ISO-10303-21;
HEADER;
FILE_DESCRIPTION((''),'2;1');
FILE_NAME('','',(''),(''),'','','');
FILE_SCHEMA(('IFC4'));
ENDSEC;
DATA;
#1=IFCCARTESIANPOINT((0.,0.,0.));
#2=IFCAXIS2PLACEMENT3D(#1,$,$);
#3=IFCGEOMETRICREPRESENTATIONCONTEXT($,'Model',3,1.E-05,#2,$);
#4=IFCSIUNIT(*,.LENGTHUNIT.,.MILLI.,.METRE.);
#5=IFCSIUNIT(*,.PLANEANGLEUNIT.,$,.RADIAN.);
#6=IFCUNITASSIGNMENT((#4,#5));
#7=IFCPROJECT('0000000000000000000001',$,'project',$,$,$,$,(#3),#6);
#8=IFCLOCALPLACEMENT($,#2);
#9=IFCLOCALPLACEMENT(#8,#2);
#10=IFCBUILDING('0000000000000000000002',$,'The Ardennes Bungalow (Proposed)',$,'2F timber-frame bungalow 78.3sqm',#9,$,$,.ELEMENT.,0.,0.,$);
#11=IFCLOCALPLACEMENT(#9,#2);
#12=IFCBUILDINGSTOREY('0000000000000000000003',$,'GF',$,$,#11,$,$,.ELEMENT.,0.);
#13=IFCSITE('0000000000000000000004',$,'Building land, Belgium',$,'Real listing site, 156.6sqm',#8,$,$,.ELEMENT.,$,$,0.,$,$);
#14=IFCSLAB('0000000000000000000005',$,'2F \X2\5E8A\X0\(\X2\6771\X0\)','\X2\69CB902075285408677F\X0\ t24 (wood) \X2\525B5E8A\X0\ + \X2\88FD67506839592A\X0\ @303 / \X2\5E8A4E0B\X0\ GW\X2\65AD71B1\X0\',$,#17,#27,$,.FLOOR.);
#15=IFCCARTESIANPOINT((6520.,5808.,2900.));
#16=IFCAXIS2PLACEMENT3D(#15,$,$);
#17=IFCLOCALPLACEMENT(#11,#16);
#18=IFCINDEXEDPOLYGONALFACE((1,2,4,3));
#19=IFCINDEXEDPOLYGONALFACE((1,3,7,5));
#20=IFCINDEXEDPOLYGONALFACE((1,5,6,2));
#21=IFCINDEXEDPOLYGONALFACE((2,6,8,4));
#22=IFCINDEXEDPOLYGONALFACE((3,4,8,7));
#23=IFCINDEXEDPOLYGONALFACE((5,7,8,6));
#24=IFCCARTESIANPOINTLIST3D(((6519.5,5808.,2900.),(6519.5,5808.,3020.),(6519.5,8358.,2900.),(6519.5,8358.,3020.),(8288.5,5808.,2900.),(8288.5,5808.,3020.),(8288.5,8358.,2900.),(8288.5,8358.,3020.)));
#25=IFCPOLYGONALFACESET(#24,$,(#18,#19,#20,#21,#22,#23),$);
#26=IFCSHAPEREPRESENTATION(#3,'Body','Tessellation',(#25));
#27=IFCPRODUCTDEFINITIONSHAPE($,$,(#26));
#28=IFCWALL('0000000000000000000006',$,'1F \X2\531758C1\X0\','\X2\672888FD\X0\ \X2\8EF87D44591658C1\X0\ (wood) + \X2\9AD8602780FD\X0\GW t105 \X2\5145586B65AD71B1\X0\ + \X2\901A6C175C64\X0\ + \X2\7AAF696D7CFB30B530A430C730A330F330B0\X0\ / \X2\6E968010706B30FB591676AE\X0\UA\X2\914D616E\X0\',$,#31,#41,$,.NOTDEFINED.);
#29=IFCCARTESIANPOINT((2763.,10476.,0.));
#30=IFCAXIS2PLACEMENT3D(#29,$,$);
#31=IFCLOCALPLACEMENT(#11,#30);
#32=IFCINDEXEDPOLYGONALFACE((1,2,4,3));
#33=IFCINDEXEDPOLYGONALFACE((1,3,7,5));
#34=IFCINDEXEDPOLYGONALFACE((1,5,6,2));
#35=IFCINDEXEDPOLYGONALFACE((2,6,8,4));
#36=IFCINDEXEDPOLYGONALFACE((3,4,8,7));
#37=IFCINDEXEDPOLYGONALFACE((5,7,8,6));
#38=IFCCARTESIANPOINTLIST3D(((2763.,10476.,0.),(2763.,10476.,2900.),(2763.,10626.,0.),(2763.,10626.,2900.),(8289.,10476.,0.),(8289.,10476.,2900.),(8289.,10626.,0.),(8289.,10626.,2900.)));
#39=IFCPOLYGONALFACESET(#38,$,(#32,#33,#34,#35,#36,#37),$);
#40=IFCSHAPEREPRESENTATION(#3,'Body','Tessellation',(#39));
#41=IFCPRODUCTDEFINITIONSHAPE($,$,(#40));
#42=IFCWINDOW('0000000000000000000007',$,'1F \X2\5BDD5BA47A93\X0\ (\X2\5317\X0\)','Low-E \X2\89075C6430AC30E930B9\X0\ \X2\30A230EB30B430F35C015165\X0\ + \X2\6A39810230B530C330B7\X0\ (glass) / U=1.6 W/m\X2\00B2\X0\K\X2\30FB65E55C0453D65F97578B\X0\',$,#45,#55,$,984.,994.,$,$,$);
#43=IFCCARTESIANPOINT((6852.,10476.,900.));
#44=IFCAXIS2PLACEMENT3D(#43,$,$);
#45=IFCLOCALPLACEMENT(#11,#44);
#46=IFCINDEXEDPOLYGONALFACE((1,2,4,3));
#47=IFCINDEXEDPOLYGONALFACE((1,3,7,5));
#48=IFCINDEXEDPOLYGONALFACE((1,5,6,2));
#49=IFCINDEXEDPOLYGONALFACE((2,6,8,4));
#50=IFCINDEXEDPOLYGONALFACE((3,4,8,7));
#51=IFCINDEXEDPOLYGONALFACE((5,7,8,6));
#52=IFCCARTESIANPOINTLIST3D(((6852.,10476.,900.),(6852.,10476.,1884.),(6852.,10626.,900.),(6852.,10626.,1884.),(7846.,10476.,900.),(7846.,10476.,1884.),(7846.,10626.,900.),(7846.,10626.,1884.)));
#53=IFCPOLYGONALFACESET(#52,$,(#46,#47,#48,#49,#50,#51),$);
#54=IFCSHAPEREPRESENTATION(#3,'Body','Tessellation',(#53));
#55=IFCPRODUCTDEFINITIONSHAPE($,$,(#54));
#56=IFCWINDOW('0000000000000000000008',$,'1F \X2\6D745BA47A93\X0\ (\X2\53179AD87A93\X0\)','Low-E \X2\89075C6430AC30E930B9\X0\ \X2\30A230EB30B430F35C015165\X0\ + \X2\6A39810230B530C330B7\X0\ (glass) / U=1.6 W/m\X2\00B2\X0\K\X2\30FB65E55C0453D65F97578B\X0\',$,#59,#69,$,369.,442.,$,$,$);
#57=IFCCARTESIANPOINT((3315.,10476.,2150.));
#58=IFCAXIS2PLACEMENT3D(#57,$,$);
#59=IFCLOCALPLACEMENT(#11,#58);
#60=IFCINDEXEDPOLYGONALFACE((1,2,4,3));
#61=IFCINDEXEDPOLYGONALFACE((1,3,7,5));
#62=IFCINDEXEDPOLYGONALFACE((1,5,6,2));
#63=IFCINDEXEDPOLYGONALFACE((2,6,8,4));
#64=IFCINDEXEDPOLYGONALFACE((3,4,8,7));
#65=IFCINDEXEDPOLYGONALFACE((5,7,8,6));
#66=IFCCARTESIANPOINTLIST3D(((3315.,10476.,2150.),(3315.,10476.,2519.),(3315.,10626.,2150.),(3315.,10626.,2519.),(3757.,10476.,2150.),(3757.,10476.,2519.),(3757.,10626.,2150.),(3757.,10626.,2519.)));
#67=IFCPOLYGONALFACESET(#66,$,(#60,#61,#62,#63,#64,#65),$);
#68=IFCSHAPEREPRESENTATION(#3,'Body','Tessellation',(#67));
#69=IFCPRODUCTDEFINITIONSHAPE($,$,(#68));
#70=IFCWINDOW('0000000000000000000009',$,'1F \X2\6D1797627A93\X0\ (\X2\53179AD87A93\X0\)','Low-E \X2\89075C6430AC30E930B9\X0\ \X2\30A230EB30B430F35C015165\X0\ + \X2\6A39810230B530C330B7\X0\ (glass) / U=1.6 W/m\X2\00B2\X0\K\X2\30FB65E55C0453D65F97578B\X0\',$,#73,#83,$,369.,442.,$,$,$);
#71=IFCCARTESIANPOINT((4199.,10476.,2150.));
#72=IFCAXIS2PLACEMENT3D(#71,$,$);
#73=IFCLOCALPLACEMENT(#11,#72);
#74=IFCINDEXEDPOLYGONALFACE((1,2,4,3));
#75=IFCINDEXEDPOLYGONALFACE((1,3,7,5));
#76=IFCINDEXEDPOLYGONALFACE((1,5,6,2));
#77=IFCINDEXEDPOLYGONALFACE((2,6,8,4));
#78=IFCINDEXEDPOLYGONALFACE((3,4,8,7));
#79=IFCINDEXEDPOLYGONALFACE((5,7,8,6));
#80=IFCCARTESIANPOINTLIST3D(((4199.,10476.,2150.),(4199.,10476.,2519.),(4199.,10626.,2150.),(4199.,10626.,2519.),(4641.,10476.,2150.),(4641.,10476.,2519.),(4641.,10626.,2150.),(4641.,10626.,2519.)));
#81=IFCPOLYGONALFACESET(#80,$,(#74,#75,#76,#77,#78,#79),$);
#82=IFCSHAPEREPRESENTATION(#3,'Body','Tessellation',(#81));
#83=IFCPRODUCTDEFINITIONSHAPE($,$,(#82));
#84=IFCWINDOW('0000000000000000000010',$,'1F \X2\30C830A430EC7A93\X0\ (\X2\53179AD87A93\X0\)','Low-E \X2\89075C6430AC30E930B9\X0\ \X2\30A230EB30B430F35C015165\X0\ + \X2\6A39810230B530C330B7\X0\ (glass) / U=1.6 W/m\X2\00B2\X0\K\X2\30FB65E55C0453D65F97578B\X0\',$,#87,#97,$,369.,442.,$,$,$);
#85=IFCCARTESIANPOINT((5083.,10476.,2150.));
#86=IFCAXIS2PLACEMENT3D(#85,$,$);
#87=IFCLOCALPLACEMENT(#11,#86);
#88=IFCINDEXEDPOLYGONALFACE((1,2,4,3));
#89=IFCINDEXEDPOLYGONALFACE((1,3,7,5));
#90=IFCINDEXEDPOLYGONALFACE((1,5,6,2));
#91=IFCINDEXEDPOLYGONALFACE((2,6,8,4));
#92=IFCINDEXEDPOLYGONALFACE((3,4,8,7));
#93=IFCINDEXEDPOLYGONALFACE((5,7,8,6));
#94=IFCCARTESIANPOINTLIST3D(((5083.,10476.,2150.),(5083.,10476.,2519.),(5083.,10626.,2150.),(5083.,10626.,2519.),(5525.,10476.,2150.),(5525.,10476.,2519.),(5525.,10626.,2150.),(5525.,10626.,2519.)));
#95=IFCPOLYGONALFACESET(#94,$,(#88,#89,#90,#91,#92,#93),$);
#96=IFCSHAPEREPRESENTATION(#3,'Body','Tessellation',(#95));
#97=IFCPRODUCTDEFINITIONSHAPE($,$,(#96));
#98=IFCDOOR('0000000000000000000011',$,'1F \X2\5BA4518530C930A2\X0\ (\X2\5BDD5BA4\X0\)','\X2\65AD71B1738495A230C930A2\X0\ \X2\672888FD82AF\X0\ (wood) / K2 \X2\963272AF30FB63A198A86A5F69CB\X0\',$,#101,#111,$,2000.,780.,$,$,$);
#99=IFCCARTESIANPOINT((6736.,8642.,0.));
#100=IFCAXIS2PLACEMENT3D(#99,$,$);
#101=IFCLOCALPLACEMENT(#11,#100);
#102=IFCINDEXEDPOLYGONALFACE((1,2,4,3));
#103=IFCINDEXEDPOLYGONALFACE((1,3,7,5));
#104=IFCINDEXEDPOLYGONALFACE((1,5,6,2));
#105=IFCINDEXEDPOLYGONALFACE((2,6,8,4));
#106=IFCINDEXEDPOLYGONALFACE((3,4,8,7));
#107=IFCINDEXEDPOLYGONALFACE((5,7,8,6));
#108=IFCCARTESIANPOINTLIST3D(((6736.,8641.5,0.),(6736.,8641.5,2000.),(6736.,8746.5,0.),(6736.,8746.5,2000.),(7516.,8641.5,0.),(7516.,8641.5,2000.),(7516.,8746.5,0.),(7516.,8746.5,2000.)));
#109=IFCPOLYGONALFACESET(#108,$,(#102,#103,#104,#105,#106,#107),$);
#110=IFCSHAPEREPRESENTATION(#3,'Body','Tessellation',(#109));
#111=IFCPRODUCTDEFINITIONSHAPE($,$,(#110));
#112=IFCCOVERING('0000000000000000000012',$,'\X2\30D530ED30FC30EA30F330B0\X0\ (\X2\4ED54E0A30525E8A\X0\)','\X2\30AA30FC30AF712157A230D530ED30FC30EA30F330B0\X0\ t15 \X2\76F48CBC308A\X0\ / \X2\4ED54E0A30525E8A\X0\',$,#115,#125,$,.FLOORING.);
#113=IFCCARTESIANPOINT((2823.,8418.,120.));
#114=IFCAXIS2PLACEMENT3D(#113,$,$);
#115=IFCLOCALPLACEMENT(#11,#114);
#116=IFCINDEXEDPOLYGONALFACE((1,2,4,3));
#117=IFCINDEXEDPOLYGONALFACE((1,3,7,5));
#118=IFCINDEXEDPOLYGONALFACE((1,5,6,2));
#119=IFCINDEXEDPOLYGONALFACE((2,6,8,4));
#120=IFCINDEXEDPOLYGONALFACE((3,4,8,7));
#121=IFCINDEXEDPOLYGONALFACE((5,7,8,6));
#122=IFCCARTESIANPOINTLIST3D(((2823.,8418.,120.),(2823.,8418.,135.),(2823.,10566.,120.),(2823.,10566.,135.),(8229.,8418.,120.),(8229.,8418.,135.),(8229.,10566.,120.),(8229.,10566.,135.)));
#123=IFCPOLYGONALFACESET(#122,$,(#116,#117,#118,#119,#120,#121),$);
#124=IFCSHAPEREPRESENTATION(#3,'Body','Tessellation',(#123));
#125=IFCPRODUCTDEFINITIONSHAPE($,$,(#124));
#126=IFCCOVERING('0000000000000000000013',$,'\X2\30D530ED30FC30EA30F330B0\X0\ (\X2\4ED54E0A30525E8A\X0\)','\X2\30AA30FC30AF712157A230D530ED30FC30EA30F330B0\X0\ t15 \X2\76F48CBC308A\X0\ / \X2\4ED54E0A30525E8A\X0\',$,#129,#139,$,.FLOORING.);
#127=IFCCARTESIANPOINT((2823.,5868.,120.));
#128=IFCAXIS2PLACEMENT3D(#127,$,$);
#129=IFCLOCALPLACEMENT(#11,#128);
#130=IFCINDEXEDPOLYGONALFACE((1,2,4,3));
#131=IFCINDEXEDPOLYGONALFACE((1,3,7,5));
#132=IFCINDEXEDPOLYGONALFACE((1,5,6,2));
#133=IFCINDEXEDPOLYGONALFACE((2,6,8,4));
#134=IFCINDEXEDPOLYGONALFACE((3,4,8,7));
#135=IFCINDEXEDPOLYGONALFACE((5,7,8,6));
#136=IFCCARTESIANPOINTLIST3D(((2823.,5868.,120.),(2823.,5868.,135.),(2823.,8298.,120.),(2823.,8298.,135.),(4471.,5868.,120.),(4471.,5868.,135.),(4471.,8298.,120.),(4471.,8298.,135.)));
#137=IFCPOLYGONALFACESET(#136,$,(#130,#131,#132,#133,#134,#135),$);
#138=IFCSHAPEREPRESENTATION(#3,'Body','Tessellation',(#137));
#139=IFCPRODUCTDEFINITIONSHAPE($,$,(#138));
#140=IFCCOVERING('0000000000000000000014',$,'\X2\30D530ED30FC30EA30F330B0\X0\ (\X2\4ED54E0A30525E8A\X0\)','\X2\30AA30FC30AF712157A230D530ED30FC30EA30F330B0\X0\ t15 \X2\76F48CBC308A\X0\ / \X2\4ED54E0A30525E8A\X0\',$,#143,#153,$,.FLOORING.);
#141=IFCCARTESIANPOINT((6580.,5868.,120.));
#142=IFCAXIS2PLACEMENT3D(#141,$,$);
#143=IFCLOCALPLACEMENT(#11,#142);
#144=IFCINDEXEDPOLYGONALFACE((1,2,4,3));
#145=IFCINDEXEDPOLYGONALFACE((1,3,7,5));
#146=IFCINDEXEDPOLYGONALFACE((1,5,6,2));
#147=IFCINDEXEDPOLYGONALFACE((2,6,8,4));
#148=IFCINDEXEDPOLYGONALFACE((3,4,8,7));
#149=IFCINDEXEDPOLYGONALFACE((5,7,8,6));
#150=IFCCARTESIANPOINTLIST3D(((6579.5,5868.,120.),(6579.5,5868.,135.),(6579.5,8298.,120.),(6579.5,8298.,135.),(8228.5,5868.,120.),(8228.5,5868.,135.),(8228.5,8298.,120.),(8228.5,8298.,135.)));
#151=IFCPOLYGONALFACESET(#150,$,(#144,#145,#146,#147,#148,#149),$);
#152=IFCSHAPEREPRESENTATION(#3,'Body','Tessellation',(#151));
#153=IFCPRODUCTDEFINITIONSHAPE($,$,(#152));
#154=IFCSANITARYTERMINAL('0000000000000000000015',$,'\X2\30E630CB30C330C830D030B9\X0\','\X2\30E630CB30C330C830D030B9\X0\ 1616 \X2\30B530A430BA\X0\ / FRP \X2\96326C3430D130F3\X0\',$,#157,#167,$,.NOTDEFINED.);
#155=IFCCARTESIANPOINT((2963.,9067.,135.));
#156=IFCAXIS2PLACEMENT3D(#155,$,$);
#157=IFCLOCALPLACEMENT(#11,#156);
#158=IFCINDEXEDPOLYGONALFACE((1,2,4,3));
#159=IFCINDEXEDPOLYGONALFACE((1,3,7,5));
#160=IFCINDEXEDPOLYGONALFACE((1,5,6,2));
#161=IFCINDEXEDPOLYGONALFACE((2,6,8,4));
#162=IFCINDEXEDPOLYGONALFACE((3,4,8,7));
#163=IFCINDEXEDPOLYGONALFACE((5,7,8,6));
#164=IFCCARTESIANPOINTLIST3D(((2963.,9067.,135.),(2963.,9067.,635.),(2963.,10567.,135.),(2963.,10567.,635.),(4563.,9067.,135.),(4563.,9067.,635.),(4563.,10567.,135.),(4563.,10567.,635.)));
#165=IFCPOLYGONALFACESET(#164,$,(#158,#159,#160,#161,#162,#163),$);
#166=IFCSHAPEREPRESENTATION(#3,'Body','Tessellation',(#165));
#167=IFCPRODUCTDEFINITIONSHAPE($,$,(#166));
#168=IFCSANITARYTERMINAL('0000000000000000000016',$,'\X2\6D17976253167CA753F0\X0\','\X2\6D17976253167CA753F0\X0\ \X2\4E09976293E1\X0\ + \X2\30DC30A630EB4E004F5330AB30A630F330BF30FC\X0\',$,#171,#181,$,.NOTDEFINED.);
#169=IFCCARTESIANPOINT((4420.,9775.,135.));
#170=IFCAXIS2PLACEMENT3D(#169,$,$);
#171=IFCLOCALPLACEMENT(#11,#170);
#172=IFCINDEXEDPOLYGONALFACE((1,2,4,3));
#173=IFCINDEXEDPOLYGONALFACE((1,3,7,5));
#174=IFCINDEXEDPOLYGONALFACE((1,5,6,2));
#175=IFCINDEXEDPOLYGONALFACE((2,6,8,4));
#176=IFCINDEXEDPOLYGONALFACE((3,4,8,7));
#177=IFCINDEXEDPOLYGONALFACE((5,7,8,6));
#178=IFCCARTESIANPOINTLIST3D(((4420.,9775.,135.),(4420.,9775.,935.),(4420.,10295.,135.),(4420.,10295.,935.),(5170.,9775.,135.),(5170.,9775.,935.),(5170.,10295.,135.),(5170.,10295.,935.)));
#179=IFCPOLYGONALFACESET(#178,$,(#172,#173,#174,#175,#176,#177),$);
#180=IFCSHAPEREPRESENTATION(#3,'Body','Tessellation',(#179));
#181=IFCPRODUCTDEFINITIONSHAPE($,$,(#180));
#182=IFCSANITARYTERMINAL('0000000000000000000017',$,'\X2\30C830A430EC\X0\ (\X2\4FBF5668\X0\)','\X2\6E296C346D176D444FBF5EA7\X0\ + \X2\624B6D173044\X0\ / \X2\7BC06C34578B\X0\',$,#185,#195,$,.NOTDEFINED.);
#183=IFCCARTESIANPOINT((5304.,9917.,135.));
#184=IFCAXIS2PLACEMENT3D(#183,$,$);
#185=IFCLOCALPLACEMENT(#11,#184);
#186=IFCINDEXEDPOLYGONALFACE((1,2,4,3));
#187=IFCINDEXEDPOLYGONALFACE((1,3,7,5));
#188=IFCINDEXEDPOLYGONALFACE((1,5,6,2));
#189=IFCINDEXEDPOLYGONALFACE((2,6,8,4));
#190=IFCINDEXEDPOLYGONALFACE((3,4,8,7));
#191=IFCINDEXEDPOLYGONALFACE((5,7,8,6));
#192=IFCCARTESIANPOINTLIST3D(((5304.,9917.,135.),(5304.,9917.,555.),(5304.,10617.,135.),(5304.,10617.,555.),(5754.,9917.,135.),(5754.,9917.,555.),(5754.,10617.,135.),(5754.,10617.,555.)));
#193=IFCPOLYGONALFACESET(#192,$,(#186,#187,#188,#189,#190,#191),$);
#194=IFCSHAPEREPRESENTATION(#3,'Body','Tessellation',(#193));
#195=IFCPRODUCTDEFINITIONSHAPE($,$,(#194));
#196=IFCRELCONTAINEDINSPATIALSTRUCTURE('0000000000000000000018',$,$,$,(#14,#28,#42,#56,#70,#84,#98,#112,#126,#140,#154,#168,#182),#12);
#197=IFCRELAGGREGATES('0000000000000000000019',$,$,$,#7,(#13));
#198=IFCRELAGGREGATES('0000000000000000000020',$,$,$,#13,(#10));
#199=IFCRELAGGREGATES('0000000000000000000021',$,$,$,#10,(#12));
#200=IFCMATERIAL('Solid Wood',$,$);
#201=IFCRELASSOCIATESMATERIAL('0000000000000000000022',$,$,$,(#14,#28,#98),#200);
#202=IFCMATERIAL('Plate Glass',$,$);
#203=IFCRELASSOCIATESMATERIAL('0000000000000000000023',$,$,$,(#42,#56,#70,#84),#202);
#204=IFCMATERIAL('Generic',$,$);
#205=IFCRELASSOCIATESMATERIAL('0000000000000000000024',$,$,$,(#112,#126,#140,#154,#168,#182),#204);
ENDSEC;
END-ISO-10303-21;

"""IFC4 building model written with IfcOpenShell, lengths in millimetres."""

from ifc_helpers import new_model, si_unit, frame, frame_2d, origin, place, context, project, spatial, rectangle, extrude, material, element, fill, save


model = new_model("IFC4")

# Units and contexts
model_context = context("Model", 3, precision=1e-05, world=origin())
ifc_project = project(units=[si_unit("LENGTHUNIT", "METRE", prefix="MILLI"), si_unit("PLANEANGLEUNIT", "RADIAN")], contexts=[model_context])

# Site, building, storey
site_placement = place(None, origin())
site = spatial("IfcSite", under=ifc_project, at=site_placement, Name="Building land, Belgium", ObjectType="Real listing site, 156.6sqm", CompositionType="ELEMENT", RefElevation=0.0)
building_placement = place(site_placement, origin())
building = spatial("IfcBuilding", under=site, at=building_placement, Name="The Ardennes Bungalow (Proposed)", ObjectType="2F timber-frame bungalow 78.3sqm", CompositionType="ELEMENT", ElevationOfRefHeight=0.0, ElevationOfTerrain=0.0)
storey_placement = place(building_placement, origin())
storey = spatial("IfcBuildingStorey", under=building, at=storey_placement, Name="GF", CompositionType="ELEMENT", Elevation=0.0)

# Slab
ifc_material_1 = material(Name="Solid Wood")
slab_1_placement = place(storey_placement, frame((6520.0, 5808.0, 2900.0)))
element("IfcSlab", 1, at=slab_1_placement, inside=storey, material=ifc_material_1, Name="2F 床(東)", Description="構造用合板 t24 (wood) 剛床 + 製材根太 @303 / 床下 GW断熱", PredefinedType="FLOOR", context=model_context, shape_type="SweptSolid", body=[
    extrude(rectangle(XDim=1769.0, YDim=2550.0, at=frame_2d((884.0, 1275.0))), frame((6520.0, 5808.0, 2900.0)), (0.0, 0.0, 1.0), 120.0),
])

# Wall, openings, windows
wall_1_placement = place(storey_placement, frame((2763.0, 10476.0, 0.0)))
wall_1 = element("IfcWall", 2, at=wall_1_placement, inside=storey, material=ifc_material_1, Name="1F 北壁", Description="木製 軸組外壁 (wood) + 高性能GW t105 充填断熱 + 通気層 + 窯業系サイディング / 準耐火・外皮UA配慮", PredefinedType="NOTDEFINED", context=model_context, shape_type="SweptSolid", body=[
    extrude(rectangle(XDim=5526.0, YDim=150.0, at=frame_2d((2763.0, 75.0))), frame((2763.0, 10476.0, 0.0)), (0.0, 0.0, 1.0), 2900.0),
])
opening_1_placement = place(storey_placement, frame((6852.0, 10476.0, 900.0)))
opening_1 = element("IfcOpeningElement", 3, at=opening_1_placement, cuts=wall_1, PredefinedType="NOTDEFINED", context=model_context, shape_type="SweptSolid", body=[
    extrude(rectangle(XDim=994.0, YDim=150.0, at=frame_2d((497.0, 75.0))), frame((6852.0, 10476.0, 900.0)), (0.0, 0.0, 1.0), 984.0),
])
opening_2_placement = place(storey_placement, frame((3315.0, 10476.0, 2150.0)))
opening_2 = element("IfcOpeningElement", 4, at=opening_2_placement, cuts=wall_1, PredefinedType="NOTDEFINED", context=model_context, shape_type="SweptSolid", body=[
    extrude(rectangle(XDim=442.0, YDim=150.0, at=frame_2d((221.0, 75.0))), frame((3315.0, 10476.0, 2150.0)), (0.0, 0.0, 1.0), 369.0),
])
opening_3_placement = place(storey_placement, frame((4199.0, 10476.0, 2150.0)))
opening_3 = element("IfcOpeningElement", 5, at=opening_3_placement, cuts=wall_1, PredefinedType="NOTDEFINED", context=model_context, shape_type="SweptSolid", body=[
    extrude(rectangle(XDim=442.0, YDim=150.0, at=frame_2d((221.0, 75.0))), frame((4199.0, 10476.0, 2150.0)), (0.0, 0.0, 1.0), 369.0),
])
opening_4_placement = place(storey_placement, frame((5083.0, 10476.0, 2150.0)))
opening_4 = element("IfcOpeningElement", 6, at=opening_4_placement, cuts=wall_1, PredefinedType="NOTDEFINED", context=model_context, shape_type="SweptSolid", body=[
    extrude(rectangle(XDim=442.0, YDim=150.0, at=frame_2d((221.0, 75.0))), frame((5083.0, 10476.0, 2150.0)), (0.0, 0.0, 1.0), 369.0),
])
ifc_material_2 = material(Name="Plate Glass")
window_1_placement = place(storey_placement, frame((6852.0, 10476.0, 900.0)))
window_1 = element("IfcWindow", 7, at=window_1_placement, inside=storey, material=ifc_material_2, Name="1F 寝室窓 (北)", Description="Low-E 複層ガラス アルゴン封入 + 樹脂サッシ (glass) / U=1.6 W/m²K・日射取得型", OverallHeight=984.0, OverallWidth=994.0, context=model_context, shape_type="SweptSolid", body=[
    extrude(rectangle(XDim=994.0, YDim=150.0, at=frame_2d((497.0, 75.0))), frame((6852.0, 10476.0, 900.0)), (0.0, 0.0, 1.0), 984.0),
])
fill(opening_1, window_1)
window_2_placement = place(storey_placement, frame((3315.0, 10476.0, 2150.0)))
window_2 = element("IfcWindow", 8, at=window_2_placement, inside=storey, material=ifc_material_2, Name="1F 浴室窓 (北高窓)", Description="Low-E 複層ガラス アルゴン封入 + 樹脂サッシ (glass) / U=1.6 W/m²K・日射取得型", OverallHeight=369.0, OverallWidth=442.0, context=model_context, shape_type="SweptSolid", body=[
    extrude(rectangle(XDim=442.0, YDim=150.0, at=frame_2d((221.0, 75.0))), frame((3315.0, 10476.0, 2150.0)), (0.0, 0.0, 1.0), 369.0),
])
fill(opening_2, window_2)
window_3_placement = place(storey_placement, frame((4199.0, 10476.0, 2150.0)))
window_3 = element("IfcWindow", 9, at=window_3_placement, inside=storey, material=ifc_material_2, Name="1F 洗面窓 (北高窓)", Description="Low-E 複層ガラス アルゴン封入 + 樹脂サッシ (glass) / U=1.6 W/m²K・日射取得型", OverallHeight=369.0, OverallWidth=442.0, context=model_context, shape_type="SweptSolid", body=[
    extrude(rectangle(XDim=442.0, YDim=150.0, at=frame_2d((221.0, 75.0))), frame((4199.0, 10476.0, 2150.0)), (0.0, 0.0, 1.0), 369.0),
])
fill(opening_3, window_3)
window_4_placement = place(storey_placement, frame((5083.0, 10476.0, 2150.0)))
window_4 = element("IfcWindow", 10, at=window_4_placement, inside=storey, material=ifc_material_2, Name="1F トイレ窓 (北高窓)", Description="Low-E 複層ガラス アルゴン封入 + 樹脂サッシ (glass) / U=1.6 W/m²K・日射取得型", OverallHeight=369.0, OverallWidth=442.0, context=model_context, shape_type="SweptSolid", body=[
    extrude(rectangle(XDim=442.0, YDim=150.0, at=frame_2d((221.0, 75.0))), frame((5083.0, 10476.0, 2150.0)), (0.0, 0.0, 1.0), 369.0),
])
fill(opening_4, window_4)

# Door
door_1_placement = place(storey_placement, frame((6736.0, 8642.0, 0.0)))
element("IfcDoor", 11, at=door_1_placement, inside=storey, material=ifc_material_1, Name="1F 室内ドア (寝室)", Description="断熱玄関ドア 木製芯 (wood) / K2 防犯・採風機構", OverallHeight=2000.0, OverallWidth=780.0, context=model_context, shape_type="SweptSolid", body=[
    extrude(rectangle(XDim=780.0, YDim=105.0, at=frame_2d((390.0, 52.0))), frame((6736.0, 8642.0, 0.0)), (0.0, 0.0, 1.0), 2000.0),
])

# Coverings
ifc_material_3 = material(Name="Generic")
covering_1_placement = place(storey_placement, frame((2823.0, 8418.0, 120.0)))
element("IfcCovering", 12, at=covering_1_placement, inside=storey, material=ifc_material_3, Name="フローリング (仕上げ床)", Description="オーク無垢フローリング t15 直貼り / 仕上げ床", PredefinedType="FLOORING", context=model_context, shape_type="SweptSolid", body=[
    extrude(rectangle(XDim=5406.0, YDim=2148.0, at=frame_2d((2703.0, 1074.0))), frame((2823.0, 8418.0, 120.0)), (0.0, 0.0, 1.0), 15.0),
])
covering_2_placement = place(storey_placement, frame((2823.0, 5868.0, 120.0)))
element("IfcCovering", 13, at=covering_2_placement, inside=storey, material=ifc_material_3, Name="フローリング (仕上げ床)", Description="オーク無垢フローリング t15 直貼り / 仕上げ床", PredefinedType="FLOORING", context=model_context, shape_type="SweptSolid", body=[
    extrude(rectangle(XDim=1648.0, YDim=2430.0, at=frame_2d((824.0, 1215.0))), frame((2823.0, 5868.0, 120.0)), (0.0, 0.0, 1.0), 15.0),
])
covering_3_placement = place(storey_placement, frame((6580.0, 5868.0, 120.0)))
element("IfcCovering", 14, at=covering_3_placement, inside=storey, material=ifc_material_3, Name="フローリング (仕上げ床)", Description="オーク無垢フローリング t15 直貼り / 仕上げ床", PredefinedType="FLOORING", context=model_context, shape_type="SweptSolid", body=[
    extrude(rectangle(XDim=1649.0, YDim=2430.0, at=frame_2d((824.0, 1215.0))), frame((6580.0, 5868.0, 120.0)), (0.0, 0.0, 1.0), 15.0),
])

# Sanitary terminals
sanitary_terminal_1_placement = place(storey_placement, frame((2963.0, 9067.0, 135.0)))
element("IfcSanitaryTerminal", 15, at=sanitary_terminal_1_placement, inside=storey, material=ifc_material_3, Name="ユニットバス", Description="ユニットバス 1616 サイズ / FRP 防水パン", PredefinedType="NOTDEFINED", context=model_context, shape_type="SweptSolid", body=[
    extrude(rectangle(XDim=1600.0, YDim=1500.0, at=frame_2d((800.0, 750.0))), frame((2963.0, 9067.0, 135.0)), (0.0, 0.0, 1.0), 500.0),
])
sanitary_terminal_2_placement = place(storey_placement, frame((4420.0, 9775.0, 135.0)))
element("IfcSanitaryTerminal", 16, at=sanitary_terminal_2_placement, inside=storey, material=ifc_material_3, Name="洗面化粧台", Description="洗面化粧台 三面鏡 + ボウル一体カウンター", PredefinedType="NOTDEFINED", context=model_context, shape_type="SweptSolid", body=[
    extrude(rectangle(XDim=750.0, YDim=520.0, at=frame_2d((375.0, 260.0))), frame((4420.0, 9775.0, 135.0)), (0.0, 0.0, 1.0), 800.0),
])
sanitary_terminal_3_placement = place(storey_placement, frame((5304.0, 9917.0, 135.0)))
element("IfcSanitaryTerminal", 17, at=sanitary_terminal_3_placement, inside=storey, material=ifc_material_3, Name="トイレ (便器)", Description="温水洗浄便座 + 手洗い / 節水型", PredefinedType="NOTDEFINED", context=model_context, shape_type="SweptSolid", body=[
    extrude(rectangle(XDim=450.0, YDim=700.0, at=frame_2d((225.0, 350.0))), frame((5304.0, 9917.0, 135.0)), (0.0, 0.0, 1.0), 420.0),
])

save(model, "model.ifc")
